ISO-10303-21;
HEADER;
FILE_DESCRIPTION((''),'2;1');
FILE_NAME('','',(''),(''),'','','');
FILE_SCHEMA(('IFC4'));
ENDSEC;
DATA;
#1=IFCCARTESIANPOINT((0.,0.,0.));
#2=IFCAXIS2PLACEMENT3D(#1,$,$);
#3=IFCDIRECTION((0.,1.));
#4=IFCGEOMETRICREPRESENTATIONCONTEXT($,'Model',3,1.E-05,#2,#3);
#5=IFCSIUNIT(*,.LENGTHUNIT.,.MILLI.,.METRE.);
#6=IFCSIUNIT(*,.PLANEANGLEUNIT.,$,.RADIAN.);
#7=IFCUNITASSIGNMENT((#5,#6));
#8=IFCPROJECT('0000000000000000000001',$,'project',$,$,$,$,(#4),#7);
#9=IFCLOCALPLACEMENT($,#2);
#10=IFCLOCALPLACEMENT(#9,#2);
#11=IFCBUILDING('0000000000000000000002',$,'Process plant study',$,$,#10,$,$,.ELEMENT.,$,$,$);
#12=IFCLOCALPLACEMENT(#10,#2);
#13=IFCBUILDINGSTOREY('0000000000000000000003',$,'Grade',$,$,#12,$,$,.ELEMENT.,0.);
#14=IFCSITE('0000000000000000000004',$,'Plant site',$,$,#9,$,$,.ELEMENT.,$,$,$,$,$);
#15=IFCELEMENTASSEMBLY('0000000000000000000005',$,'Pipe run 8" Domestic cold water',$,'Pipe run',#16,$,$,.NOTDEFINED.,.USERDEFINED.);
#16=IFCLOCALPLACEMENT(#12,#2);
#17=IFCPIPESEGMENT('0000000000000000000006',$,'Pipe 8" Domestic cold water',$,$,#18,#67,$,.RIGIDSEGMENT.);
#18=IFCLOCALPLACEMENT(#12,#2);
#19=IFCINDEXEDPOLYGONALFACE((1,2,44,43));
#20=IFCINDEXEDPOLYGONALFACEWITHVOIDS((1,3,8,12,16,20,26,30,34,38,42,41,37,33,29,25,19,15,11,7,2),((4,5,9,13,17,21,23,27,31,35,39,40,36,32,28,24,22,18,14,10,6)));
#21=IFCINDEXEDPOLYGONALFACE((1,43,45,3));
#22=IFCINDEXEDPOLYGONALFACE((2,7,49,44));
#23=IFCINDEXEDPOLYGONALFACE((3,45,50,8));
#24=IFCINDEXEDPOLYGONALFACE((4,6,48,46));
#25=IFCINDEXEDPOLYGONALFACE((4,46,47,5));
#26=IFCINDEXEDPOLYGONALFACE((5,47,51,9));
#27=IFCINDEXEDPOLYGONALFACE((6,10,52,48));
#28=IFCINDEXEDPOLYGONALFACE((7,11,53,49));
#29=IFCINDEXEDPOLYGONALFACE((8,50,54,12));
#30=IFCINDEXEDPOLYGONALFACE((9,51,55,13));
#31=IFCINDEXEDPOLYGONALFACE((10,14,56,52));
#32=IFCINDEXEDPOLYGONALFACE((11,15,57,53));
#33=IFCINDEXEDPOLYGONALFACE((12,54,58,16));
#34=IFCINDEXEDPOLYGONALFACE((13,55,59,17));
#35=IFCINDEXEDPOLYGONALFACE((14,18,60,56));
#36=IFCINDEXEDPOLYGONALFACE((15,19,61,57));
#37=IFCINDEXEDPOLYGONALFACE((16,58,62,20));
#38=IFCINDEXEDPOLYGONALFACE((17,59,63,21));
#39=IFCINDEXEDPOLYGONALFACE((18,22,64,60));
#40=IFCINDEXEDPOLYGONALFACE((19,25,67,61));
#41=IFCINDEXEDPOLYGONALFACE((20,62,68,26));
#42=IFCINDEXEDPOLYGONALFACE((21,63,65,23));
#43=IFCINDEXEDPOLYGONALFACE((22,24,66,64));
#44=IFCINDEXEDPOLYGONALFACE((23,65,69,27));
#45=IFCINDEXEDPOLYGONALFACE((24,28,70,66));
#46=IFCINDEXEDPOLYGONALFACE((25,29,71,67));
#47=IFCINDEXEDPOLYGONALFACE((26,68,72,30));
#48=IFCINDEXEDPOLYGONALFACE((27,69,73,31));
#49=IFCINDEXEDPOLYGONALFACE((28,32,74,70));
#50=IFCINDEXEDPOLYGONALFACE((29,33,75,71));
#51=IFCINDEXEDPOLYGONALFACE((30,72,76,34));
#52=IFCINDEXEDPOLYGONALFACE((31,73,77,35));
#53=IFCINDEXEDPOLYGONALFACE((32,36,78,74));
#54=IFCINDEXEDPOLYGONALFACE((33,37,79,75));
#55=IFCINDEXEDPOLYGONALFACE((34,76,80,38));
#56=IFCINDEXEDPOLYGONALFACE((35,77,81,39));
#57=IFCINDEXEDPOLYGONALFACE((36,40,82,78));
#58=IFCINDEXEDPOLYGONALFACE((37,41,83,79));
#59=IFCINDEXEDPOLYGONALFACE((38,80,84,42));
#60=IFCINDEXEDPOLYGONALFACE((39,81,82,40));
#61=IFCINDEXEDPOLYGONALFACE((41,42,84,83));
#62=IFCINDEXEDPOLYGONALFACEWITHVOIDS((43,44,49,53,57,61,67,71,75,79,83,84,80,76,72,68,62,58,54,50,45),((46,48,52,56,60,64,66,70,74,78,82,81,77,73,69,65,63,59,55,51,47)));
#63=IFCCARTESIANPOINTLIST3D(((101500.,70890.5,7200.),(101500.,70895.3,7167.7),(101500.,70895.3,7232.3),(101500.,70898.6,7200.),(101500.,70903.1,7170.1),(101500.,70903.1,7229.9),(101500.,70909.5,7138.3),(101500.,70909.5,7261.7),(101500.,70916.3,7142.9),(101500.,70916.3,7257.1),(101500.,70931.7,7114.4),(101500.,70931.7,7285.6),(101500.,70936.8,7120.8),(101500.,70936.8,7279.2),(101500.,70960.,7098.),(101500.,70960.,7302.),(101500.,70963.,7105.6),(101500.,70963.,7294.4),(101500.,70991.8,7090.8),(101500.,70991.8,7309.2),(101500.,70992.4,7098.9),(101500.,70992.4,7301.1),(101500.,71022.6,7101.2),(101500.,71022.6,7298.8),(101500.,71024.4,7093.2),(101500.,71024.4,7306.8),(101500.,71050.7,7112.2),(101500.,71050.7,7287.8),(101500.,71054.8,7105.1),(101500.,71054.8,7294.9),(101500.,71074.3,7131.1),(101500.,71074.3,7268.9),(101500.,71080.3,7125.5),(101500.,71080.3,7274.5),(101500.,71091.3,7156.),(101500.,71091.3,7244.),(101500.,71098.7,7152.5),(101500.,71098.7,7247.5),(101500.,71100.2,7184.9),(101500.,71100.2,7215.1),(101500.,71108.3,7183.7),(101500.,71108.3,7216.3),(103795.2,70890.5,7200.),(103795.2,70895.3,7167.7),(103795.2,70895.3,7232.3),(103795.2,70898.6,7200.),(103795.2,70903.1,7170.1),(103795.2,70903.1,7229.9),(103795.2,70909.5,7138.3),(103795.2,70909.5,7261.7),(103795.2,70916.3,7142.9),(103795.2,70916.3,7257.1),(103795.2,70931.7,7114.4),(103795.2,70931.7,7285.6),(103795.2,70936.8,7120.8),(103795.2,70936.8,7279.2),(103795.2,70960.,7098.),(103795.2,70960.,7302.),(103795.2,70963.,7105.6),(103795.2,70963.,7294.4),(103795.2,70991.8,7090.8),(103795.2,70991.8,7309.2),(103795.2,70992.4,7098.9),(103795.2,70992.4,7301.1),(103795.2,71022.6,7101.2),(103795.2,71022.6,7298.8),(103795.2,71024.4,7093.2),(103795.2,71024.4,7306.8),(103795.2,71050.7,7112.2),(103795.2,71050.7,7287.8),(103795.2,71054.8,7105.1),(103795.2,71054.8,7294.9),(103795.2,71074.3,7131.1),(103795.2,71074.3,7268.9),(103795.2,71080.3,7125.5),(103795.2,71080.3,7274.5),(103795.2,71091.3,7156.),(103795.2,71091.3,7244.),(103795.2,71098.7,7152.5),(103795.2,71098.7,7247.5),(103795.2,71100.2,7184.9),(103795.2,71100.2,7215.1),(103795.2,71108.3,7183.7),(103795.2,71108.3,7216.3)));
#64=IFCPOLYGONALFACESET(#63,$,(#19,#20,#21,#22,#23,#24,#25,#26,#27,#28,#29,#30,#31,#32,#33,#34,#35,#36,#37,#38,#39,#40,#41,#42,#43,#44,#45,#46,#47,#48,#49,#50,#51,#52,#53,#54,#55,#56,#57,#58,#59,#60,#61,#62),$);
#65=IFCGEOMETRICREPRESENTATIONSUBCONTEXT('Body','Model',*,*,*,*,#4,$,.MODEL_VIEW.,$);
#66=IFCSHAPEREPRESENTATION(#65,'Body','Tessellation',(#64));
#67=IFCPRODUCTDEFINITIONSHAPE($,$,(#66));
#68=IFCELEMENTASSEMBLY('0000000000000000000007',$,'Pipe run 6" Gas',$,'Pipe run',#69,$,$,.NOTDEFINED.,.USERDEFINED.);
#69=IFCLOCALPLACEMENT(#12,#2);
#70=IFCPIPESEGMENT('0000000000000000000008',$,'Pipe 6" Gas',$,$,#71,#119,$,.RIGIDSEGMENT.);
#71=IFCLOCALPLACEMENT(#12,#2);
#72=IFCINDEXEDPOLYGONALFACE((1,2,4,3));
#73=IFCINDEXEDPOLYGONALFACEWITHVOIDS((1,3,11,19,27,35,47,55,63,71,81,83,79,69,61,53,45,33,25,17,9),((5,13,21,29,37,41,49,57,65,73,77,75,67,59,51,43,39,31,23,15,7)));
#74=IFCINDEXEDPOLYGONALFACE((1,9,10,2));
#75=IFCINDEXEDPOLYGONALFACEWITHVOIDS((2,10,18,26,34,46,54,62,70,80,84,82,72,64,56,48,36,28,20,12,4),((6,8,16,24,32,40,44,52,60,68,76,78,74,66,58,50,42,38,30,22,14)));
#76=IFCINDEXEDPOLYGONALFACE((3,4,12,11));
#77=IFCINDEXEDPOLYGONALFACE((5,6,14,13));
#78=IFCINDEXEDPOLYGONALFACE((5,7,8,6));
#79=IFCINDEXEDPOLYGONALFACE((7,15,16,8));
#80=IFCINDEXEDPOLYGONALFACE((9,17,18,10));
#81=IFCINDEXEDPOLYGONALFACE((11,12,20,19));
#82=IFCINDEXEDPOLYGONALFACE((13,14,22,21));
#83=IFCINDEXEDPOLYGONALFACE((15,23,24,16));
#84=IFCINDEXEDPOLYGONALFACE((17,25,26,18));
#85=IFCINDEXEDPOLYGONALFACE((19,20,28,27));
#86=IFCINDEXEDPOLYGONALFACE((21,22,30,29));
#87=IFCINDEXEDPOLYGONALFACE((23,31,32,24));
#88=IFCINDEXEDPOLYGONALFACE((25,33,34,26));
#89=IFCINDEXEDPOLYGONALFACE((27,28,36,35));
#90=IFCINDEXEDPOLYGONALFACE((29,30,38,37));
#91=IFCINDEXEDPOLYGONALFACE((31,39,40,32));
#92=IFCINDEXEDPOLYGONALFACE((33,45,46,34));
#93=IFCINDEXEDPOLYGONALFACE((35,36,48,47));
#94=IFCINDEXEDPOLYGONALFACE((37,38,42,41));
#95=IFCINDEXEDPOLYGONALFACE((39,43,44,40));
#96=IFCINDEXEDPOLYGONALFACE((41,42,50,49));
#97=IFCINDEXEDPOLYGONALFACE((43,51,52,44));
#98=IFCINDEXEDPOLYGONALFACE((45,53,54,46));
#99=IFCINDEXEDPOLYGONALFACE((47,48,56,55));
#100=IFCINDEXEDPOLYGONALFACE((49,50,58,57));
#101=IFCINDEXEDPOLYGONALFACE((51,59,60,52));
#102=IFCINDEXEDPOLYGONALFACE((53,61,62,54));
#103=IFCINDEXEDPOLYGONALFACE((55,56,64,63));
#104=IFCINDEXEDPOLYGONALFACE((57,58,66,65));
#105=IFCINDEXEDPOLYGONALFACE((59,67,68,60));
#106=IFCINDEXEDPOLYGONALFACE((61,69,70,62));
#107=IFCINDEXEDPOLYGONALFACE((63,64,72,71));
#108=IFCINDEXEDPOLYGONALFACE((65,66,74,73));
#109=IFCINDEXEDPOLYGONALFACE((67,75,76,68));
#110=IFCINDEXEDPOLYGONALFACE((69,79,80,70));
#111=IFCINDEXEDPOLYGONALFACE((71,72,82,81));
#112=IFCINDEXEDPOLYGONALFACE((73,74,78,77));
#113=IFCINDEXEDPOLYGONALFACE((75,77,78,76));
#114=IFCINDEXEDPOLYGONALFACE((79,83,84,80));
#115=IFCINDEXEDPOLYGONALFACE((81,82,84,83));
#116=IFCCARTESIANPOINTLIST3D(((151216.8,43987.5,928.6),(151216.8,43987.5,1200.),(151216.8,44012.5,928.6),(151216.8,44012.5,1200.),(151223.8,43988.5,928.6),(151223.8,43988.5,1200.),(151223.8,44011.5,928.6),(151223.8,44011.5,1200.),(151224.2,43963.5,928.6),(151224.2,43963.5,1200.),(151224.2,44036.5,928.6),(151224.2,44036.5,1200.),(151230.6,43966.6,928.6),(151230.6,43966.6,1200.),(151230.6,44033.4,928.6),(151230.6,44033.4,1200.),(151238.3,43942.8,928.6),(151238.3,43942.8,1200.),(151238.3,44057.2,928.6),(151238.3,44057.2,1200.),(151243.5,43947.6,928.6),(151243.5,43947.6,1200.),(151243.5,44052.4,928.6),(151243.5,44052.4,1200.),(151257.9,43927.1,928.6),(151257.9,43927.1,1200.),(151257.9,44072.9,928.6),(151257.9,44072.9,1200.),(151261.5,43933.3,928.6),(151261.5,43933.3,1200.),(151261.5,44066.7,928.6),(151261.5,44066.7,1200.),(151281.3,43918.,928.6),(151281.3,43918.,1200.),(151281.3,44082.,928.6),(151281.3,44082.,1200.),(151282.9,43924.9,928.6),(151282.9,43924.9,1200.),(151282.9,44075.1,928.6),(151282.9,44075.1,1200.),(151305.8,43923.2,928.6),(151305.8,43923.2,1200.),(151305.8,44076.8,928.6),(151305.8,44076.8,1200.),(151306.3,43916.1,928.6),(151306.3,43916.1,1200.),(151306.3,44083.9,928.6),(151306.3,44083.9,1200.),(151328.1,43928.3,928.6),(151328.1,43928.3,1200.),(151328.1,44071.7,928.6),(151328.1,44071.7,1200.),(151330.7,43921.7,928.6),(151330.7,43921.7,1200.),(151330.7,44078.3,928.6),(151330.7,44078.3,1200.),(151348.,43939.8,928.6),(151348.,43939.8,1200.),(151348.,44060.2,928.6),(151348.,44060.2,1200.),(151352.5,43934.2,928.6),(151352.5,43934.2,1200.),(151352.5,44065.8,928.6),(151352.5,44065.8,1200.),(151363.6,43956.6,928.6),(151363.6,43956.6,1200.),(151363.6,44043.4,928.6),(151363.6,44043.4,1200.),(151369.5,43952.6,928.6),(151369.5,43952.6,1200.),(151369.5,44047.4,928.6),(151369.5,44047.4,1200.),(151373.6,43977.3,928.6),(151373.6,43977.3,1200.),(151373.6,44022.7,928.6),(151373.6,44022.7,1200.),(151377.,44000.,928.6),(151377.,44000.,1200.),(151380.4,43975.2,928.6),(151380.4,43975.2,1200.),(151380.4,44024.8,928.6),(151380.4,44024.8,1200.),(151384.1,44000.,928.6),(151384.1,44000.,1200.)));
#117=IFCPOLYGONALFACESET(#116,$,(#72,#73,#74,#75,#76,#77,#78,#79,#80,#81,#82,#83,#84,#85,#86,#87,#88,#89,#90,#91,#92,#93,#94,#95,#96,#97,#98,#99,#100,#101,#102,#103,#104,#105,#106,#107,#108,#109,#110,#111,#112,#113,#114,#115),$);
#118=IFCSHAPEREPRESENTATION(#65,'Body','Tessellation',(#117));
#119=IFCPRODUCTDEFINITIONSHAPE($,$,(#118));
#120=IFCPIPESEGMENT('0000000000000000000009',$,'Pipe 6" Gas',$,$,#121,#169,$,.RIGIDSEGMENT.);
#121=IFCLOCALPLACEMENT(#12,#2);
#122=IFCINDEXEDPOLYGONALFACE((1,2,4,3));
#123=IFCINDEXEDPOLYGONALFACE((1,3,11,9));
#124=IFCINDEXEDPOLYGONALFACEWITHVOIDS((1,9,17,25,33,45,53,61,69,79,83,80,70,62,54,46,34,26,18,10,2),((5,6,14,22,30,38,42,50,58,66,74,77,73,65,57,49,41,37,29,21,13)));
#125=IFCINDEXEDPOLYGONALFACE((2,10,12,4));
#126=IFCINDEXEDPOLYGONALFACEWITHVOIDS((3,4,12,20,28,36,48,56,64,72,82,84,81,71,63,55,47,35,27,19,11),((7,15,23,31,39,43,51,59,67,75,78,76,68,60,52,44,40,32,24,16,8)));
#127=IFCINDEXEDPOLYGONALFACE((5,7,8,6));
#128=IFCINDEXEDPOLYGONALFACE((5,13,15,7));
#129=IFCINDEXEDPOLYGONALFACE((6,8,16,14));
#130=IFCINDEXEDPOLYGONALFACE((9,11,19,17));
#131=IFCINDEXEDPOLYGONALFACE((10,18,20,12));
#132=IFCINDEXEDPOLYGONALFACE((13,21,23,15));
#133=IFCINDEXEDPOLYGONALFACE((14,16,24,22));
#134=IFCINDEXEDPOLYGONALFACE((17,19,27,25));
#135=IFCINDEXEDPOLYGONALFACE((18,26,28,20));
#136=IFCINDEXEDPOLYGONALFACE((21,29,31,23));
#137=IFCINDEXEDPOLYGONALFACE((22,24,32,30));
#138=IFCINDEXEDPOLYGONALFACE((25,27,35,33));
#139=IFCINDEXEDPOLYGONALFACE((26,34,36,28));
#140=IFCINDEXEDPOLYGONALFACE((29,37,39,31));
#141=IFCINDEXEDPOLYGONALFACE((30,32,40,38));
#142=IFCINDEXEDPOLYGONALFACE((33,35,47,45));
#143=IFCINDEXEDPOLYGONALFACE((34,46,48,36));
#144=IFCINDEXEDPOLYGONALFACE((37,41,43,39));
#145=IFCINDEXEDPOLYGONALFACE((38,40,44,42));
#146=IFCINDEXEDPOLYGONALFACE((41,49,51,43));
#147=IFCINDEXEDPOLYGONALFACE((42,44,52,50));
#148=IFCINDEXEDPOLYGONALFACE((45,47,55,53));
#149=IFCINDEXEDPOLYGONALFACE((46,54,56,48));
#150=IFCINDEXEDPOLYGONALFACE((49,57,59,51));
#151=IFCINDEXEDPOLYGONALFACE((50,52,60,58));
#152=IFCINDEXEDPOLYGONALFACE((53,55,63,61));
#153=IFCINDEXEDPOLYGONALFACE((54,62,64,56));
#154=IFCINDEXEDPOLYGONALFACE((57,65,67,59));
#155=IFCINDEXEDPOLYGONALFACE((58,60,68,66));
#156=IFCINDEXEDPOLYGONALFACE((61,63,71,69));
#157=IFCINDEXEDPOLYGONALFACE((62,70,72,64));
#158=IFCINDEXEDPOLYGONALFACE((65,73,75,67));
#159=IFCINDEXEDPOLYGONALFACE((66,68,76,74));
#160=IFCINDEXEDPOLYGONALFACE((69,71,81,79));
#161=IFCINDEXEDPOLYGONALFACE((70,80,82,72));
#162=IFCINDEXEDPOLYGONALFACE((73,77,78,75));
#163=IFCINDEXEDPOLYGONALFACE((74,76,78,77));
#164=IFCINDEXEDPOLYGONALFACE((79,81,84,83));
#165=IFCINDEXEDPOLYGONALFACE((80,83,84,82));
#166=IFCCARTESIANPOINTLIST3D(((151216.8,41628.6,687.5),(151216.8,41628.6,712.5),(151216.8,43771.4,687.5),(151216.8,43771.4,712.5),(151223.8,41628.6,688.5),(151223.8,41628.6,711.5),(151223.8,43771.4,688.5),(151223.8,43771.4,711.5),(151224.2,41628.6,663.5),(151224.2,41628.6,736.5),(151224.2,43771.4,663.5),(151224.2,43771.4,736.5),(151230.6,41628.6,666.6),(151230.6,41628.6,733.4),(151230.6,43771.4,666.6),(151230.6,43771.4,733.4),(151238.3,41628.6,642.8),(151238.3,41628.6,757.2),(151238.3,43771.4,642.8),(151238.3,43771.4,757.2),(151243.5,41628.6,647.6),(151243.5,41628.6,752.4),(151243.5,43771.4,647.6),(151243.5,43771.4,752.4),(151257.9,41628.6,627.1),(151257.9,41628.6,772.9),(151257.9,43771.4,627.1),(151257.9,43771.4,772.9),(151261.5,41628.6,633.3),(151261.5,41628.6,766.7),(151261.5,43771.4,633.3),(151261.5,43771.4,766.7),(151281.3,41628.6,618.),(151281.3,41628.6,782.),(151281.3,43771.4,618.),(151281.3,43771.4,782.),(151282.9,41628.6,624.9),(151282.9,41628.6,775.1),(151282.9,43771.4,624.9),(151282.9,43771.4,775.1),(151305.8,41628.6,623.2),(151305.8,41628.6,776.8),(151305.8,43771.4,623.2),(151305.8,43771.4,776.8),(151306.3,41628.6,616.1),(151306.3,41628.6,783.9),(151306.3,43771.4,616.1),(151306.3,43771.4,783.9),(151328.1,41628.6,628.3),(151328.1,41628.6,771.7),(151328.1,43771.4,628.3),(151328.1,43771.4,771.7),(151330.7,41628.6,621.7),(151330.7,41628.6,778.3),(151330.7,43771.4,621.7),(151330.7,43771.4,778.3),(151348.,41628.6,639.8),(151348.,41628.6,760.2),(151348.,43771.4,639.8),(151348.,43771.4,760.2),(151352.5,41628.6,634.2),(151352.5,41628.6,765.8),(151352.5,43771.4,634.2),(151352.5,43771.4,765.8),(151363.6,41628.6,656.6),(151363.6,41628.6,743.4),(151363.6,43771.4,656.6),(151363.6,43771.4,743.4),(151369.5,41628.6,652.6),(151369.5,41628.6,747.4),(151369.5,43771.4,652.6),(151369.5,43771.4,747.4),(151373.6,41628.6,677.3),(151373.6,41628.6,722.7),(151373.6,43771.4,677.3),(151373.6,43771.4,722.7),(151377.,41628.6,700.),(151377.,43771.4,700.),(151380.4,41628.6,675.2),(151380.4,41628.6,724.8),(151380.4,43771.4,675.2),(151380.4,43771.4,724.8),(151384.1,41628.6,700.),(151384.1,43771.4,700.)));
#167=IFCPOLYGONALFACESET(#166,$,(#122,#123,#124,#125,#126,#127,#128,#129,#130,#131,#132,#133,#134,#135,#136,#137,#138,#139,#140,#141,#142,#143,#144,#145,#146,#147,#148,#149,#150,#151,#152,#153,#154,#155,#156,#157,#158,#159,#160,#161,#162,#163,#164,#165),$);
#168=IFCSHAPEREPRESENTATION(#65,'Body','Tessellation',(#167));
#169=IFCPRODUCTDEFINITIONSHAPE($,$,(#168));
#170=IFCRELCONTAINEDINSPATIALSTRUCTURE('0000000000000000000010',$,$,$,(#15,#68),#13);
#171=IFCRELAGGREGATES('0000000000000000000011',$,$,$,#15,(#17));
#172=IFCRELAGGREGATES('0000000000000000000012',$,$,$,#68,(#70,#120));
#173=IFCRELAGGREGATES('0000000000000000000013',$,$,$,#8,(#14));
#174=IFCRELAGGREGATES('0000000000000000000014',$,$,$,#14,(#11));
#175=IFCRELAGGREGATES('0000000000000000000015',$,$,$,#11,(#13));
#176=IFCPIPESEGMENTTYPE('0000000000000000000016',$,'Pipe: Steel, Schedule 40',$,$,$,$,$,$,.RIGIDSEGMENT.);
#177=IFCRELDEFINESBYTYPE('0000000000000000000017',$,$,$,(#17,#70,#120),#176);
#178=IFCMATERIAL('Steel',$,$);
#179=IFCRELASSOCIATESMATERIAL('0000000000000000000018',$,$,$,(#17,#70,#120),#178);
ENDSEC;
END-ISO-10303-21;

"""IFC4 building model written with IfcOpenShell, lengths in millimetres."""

from ifc_helpers import new_model, si_unit, direction, frame, origin, origin_with_axes, origin_2d, place, context, subcontext, project, spatial, hollow_circle, extrude, material, type_object, element, aggregate, save


model = new_model("IFC4")

# Units and contexts
model_context = context("Model", 3, precision=1e-05, world=origin(), true_north=direction((0.0, 1.0)))
body_context = subcontext(model_context, "Body", "Model", "MODEL_VIEW")
ifc_project = project(units=[si_unit("LENGTHUNIT", "METRE", prefix="MILLI"), si_unit("PLANEANGLEUNIT", "RADIAN")], contexts=[model_context])

# Site, building, storey
site_placement = place(None, origin())
site = spatial("IfcSite", under=ifc_project, at=site_placement, Name="Plant site", CompositionType="ELEMENT")
building_placement = place(site_placement, origin())
building = spatial("IfcBuilding", under=site, at=building_placement, Name="Process plant study", CompositionType="ELEMENT")
storey_placement = place(building_placement, origin())
storey = spatial("IfcBuildingStorey", under=building, at=storey_placement, Name="Grade", CompositionType="ELEMENT", Elevation=0.0)

# Element assembly, pipe segment
assembly_1_placement = place(storey_placement, origin_with_axes())
assembly_1 = element("IfcElementAssembly", 1, at=assembly_1_placement, inside=storey, Name="Pipe run 8\" Domestic cold water", ObjectType="Pipe run", AssemblyPlace="NOTDEFINED", PredefinedType="USERDEFINED")
ifc_material = material(Name="Steel")
pipe_segment_type = type_object("IfcPipeSegmentType", Name="Pipe: Steel, Schedule 40", PredefinedType="RIGIDSEGMENT")
pipe_segment_1_placement = place(storey_placement, origin_with_axes())
pipe_segment_1 = element("IfcPipeSegment", 2, at=pipe_segment_1_placement, type_object=pipe_segment_type, material=ifc_material, Name="Pipe 8\" Domestic cold water", PredefinedType="RIGIDSEGMENT", context=body_context, shape_type="SweptSolid", body=[
    extrude(hollow_circle(Radius=109.5, WallThickness=8.2, at=origin_2d()), frame((103795.2, 71000.0, 7200.0), z_axis=(-1.0, 0.0, 0.0), x_axis=(0.0, -1.0, 0.0)), (0.0, 0.0, 1.0), 2295.2),
])

# Element assembly, pipe segments
assembly_2_placement = place(storey_placement, origin_with_axes())
assembly_2 = element("IfcElementAssembly", 3, at=assembly_2_placement, inside=storey, Name="Pipe run 6\" Gas", ObjectType="Pipe run", AssemblyPlace="NOTDEFINED", PredefinedType="USERDEFINED")
pipe_segment_2_placement = place(storey_placement, origin_with_axes())
pipe_segment_2 = element("IfcPipeSegment", 4, at=pipe_segment_2_placement, type_object=pipe_segment_type, material=ifc_material, Name="Pipe 6\" Gas", PredefinedType="RIGIDSEGMENT", context=body_context, shape_type="SweptSolid", body=[
    extrude(hollow_circle(Radius=84.1, WallThickness=7.1, at=origin_2d()), frame((151300.0, 44000.0, 1200.0), z_axis=(0.0, 0.0, -1.0), x_axis=(1.0, 0.0, 0.0)), (0.0, 0.0, 1.0), 271.4),
])
pipe_segment_3_placement = place(storey_placement, origin_with_axes())
pipe_segment_3 = element("IfcPipeSegment", 5, at=pipe_segment_3_placement, type_object=pipe_segment_type, material=ifc_material, Name="Pipe 6\" Gas", PredefinedType="RIGIDSEGMENT", context=body_context, shape_type="SweptSolid", body=[
    extrude(hollow_circle(Radius=84.1, WallThickness=7.1, at=origin_2d()), frame((151300.0, 43771.4, 700.0), z_axis=(0.0, -1.0, 0.0), x_axis=(1.0, 0.0, 0.0)), (0.0, 0.0, 1.0), 2142.8),
])

aggregate(assembly_1, [pipe_segment_1])
aggregate(assembly_2, [pipe_segment_2, pipe_segment_3])

save(model, "model.ifc")
